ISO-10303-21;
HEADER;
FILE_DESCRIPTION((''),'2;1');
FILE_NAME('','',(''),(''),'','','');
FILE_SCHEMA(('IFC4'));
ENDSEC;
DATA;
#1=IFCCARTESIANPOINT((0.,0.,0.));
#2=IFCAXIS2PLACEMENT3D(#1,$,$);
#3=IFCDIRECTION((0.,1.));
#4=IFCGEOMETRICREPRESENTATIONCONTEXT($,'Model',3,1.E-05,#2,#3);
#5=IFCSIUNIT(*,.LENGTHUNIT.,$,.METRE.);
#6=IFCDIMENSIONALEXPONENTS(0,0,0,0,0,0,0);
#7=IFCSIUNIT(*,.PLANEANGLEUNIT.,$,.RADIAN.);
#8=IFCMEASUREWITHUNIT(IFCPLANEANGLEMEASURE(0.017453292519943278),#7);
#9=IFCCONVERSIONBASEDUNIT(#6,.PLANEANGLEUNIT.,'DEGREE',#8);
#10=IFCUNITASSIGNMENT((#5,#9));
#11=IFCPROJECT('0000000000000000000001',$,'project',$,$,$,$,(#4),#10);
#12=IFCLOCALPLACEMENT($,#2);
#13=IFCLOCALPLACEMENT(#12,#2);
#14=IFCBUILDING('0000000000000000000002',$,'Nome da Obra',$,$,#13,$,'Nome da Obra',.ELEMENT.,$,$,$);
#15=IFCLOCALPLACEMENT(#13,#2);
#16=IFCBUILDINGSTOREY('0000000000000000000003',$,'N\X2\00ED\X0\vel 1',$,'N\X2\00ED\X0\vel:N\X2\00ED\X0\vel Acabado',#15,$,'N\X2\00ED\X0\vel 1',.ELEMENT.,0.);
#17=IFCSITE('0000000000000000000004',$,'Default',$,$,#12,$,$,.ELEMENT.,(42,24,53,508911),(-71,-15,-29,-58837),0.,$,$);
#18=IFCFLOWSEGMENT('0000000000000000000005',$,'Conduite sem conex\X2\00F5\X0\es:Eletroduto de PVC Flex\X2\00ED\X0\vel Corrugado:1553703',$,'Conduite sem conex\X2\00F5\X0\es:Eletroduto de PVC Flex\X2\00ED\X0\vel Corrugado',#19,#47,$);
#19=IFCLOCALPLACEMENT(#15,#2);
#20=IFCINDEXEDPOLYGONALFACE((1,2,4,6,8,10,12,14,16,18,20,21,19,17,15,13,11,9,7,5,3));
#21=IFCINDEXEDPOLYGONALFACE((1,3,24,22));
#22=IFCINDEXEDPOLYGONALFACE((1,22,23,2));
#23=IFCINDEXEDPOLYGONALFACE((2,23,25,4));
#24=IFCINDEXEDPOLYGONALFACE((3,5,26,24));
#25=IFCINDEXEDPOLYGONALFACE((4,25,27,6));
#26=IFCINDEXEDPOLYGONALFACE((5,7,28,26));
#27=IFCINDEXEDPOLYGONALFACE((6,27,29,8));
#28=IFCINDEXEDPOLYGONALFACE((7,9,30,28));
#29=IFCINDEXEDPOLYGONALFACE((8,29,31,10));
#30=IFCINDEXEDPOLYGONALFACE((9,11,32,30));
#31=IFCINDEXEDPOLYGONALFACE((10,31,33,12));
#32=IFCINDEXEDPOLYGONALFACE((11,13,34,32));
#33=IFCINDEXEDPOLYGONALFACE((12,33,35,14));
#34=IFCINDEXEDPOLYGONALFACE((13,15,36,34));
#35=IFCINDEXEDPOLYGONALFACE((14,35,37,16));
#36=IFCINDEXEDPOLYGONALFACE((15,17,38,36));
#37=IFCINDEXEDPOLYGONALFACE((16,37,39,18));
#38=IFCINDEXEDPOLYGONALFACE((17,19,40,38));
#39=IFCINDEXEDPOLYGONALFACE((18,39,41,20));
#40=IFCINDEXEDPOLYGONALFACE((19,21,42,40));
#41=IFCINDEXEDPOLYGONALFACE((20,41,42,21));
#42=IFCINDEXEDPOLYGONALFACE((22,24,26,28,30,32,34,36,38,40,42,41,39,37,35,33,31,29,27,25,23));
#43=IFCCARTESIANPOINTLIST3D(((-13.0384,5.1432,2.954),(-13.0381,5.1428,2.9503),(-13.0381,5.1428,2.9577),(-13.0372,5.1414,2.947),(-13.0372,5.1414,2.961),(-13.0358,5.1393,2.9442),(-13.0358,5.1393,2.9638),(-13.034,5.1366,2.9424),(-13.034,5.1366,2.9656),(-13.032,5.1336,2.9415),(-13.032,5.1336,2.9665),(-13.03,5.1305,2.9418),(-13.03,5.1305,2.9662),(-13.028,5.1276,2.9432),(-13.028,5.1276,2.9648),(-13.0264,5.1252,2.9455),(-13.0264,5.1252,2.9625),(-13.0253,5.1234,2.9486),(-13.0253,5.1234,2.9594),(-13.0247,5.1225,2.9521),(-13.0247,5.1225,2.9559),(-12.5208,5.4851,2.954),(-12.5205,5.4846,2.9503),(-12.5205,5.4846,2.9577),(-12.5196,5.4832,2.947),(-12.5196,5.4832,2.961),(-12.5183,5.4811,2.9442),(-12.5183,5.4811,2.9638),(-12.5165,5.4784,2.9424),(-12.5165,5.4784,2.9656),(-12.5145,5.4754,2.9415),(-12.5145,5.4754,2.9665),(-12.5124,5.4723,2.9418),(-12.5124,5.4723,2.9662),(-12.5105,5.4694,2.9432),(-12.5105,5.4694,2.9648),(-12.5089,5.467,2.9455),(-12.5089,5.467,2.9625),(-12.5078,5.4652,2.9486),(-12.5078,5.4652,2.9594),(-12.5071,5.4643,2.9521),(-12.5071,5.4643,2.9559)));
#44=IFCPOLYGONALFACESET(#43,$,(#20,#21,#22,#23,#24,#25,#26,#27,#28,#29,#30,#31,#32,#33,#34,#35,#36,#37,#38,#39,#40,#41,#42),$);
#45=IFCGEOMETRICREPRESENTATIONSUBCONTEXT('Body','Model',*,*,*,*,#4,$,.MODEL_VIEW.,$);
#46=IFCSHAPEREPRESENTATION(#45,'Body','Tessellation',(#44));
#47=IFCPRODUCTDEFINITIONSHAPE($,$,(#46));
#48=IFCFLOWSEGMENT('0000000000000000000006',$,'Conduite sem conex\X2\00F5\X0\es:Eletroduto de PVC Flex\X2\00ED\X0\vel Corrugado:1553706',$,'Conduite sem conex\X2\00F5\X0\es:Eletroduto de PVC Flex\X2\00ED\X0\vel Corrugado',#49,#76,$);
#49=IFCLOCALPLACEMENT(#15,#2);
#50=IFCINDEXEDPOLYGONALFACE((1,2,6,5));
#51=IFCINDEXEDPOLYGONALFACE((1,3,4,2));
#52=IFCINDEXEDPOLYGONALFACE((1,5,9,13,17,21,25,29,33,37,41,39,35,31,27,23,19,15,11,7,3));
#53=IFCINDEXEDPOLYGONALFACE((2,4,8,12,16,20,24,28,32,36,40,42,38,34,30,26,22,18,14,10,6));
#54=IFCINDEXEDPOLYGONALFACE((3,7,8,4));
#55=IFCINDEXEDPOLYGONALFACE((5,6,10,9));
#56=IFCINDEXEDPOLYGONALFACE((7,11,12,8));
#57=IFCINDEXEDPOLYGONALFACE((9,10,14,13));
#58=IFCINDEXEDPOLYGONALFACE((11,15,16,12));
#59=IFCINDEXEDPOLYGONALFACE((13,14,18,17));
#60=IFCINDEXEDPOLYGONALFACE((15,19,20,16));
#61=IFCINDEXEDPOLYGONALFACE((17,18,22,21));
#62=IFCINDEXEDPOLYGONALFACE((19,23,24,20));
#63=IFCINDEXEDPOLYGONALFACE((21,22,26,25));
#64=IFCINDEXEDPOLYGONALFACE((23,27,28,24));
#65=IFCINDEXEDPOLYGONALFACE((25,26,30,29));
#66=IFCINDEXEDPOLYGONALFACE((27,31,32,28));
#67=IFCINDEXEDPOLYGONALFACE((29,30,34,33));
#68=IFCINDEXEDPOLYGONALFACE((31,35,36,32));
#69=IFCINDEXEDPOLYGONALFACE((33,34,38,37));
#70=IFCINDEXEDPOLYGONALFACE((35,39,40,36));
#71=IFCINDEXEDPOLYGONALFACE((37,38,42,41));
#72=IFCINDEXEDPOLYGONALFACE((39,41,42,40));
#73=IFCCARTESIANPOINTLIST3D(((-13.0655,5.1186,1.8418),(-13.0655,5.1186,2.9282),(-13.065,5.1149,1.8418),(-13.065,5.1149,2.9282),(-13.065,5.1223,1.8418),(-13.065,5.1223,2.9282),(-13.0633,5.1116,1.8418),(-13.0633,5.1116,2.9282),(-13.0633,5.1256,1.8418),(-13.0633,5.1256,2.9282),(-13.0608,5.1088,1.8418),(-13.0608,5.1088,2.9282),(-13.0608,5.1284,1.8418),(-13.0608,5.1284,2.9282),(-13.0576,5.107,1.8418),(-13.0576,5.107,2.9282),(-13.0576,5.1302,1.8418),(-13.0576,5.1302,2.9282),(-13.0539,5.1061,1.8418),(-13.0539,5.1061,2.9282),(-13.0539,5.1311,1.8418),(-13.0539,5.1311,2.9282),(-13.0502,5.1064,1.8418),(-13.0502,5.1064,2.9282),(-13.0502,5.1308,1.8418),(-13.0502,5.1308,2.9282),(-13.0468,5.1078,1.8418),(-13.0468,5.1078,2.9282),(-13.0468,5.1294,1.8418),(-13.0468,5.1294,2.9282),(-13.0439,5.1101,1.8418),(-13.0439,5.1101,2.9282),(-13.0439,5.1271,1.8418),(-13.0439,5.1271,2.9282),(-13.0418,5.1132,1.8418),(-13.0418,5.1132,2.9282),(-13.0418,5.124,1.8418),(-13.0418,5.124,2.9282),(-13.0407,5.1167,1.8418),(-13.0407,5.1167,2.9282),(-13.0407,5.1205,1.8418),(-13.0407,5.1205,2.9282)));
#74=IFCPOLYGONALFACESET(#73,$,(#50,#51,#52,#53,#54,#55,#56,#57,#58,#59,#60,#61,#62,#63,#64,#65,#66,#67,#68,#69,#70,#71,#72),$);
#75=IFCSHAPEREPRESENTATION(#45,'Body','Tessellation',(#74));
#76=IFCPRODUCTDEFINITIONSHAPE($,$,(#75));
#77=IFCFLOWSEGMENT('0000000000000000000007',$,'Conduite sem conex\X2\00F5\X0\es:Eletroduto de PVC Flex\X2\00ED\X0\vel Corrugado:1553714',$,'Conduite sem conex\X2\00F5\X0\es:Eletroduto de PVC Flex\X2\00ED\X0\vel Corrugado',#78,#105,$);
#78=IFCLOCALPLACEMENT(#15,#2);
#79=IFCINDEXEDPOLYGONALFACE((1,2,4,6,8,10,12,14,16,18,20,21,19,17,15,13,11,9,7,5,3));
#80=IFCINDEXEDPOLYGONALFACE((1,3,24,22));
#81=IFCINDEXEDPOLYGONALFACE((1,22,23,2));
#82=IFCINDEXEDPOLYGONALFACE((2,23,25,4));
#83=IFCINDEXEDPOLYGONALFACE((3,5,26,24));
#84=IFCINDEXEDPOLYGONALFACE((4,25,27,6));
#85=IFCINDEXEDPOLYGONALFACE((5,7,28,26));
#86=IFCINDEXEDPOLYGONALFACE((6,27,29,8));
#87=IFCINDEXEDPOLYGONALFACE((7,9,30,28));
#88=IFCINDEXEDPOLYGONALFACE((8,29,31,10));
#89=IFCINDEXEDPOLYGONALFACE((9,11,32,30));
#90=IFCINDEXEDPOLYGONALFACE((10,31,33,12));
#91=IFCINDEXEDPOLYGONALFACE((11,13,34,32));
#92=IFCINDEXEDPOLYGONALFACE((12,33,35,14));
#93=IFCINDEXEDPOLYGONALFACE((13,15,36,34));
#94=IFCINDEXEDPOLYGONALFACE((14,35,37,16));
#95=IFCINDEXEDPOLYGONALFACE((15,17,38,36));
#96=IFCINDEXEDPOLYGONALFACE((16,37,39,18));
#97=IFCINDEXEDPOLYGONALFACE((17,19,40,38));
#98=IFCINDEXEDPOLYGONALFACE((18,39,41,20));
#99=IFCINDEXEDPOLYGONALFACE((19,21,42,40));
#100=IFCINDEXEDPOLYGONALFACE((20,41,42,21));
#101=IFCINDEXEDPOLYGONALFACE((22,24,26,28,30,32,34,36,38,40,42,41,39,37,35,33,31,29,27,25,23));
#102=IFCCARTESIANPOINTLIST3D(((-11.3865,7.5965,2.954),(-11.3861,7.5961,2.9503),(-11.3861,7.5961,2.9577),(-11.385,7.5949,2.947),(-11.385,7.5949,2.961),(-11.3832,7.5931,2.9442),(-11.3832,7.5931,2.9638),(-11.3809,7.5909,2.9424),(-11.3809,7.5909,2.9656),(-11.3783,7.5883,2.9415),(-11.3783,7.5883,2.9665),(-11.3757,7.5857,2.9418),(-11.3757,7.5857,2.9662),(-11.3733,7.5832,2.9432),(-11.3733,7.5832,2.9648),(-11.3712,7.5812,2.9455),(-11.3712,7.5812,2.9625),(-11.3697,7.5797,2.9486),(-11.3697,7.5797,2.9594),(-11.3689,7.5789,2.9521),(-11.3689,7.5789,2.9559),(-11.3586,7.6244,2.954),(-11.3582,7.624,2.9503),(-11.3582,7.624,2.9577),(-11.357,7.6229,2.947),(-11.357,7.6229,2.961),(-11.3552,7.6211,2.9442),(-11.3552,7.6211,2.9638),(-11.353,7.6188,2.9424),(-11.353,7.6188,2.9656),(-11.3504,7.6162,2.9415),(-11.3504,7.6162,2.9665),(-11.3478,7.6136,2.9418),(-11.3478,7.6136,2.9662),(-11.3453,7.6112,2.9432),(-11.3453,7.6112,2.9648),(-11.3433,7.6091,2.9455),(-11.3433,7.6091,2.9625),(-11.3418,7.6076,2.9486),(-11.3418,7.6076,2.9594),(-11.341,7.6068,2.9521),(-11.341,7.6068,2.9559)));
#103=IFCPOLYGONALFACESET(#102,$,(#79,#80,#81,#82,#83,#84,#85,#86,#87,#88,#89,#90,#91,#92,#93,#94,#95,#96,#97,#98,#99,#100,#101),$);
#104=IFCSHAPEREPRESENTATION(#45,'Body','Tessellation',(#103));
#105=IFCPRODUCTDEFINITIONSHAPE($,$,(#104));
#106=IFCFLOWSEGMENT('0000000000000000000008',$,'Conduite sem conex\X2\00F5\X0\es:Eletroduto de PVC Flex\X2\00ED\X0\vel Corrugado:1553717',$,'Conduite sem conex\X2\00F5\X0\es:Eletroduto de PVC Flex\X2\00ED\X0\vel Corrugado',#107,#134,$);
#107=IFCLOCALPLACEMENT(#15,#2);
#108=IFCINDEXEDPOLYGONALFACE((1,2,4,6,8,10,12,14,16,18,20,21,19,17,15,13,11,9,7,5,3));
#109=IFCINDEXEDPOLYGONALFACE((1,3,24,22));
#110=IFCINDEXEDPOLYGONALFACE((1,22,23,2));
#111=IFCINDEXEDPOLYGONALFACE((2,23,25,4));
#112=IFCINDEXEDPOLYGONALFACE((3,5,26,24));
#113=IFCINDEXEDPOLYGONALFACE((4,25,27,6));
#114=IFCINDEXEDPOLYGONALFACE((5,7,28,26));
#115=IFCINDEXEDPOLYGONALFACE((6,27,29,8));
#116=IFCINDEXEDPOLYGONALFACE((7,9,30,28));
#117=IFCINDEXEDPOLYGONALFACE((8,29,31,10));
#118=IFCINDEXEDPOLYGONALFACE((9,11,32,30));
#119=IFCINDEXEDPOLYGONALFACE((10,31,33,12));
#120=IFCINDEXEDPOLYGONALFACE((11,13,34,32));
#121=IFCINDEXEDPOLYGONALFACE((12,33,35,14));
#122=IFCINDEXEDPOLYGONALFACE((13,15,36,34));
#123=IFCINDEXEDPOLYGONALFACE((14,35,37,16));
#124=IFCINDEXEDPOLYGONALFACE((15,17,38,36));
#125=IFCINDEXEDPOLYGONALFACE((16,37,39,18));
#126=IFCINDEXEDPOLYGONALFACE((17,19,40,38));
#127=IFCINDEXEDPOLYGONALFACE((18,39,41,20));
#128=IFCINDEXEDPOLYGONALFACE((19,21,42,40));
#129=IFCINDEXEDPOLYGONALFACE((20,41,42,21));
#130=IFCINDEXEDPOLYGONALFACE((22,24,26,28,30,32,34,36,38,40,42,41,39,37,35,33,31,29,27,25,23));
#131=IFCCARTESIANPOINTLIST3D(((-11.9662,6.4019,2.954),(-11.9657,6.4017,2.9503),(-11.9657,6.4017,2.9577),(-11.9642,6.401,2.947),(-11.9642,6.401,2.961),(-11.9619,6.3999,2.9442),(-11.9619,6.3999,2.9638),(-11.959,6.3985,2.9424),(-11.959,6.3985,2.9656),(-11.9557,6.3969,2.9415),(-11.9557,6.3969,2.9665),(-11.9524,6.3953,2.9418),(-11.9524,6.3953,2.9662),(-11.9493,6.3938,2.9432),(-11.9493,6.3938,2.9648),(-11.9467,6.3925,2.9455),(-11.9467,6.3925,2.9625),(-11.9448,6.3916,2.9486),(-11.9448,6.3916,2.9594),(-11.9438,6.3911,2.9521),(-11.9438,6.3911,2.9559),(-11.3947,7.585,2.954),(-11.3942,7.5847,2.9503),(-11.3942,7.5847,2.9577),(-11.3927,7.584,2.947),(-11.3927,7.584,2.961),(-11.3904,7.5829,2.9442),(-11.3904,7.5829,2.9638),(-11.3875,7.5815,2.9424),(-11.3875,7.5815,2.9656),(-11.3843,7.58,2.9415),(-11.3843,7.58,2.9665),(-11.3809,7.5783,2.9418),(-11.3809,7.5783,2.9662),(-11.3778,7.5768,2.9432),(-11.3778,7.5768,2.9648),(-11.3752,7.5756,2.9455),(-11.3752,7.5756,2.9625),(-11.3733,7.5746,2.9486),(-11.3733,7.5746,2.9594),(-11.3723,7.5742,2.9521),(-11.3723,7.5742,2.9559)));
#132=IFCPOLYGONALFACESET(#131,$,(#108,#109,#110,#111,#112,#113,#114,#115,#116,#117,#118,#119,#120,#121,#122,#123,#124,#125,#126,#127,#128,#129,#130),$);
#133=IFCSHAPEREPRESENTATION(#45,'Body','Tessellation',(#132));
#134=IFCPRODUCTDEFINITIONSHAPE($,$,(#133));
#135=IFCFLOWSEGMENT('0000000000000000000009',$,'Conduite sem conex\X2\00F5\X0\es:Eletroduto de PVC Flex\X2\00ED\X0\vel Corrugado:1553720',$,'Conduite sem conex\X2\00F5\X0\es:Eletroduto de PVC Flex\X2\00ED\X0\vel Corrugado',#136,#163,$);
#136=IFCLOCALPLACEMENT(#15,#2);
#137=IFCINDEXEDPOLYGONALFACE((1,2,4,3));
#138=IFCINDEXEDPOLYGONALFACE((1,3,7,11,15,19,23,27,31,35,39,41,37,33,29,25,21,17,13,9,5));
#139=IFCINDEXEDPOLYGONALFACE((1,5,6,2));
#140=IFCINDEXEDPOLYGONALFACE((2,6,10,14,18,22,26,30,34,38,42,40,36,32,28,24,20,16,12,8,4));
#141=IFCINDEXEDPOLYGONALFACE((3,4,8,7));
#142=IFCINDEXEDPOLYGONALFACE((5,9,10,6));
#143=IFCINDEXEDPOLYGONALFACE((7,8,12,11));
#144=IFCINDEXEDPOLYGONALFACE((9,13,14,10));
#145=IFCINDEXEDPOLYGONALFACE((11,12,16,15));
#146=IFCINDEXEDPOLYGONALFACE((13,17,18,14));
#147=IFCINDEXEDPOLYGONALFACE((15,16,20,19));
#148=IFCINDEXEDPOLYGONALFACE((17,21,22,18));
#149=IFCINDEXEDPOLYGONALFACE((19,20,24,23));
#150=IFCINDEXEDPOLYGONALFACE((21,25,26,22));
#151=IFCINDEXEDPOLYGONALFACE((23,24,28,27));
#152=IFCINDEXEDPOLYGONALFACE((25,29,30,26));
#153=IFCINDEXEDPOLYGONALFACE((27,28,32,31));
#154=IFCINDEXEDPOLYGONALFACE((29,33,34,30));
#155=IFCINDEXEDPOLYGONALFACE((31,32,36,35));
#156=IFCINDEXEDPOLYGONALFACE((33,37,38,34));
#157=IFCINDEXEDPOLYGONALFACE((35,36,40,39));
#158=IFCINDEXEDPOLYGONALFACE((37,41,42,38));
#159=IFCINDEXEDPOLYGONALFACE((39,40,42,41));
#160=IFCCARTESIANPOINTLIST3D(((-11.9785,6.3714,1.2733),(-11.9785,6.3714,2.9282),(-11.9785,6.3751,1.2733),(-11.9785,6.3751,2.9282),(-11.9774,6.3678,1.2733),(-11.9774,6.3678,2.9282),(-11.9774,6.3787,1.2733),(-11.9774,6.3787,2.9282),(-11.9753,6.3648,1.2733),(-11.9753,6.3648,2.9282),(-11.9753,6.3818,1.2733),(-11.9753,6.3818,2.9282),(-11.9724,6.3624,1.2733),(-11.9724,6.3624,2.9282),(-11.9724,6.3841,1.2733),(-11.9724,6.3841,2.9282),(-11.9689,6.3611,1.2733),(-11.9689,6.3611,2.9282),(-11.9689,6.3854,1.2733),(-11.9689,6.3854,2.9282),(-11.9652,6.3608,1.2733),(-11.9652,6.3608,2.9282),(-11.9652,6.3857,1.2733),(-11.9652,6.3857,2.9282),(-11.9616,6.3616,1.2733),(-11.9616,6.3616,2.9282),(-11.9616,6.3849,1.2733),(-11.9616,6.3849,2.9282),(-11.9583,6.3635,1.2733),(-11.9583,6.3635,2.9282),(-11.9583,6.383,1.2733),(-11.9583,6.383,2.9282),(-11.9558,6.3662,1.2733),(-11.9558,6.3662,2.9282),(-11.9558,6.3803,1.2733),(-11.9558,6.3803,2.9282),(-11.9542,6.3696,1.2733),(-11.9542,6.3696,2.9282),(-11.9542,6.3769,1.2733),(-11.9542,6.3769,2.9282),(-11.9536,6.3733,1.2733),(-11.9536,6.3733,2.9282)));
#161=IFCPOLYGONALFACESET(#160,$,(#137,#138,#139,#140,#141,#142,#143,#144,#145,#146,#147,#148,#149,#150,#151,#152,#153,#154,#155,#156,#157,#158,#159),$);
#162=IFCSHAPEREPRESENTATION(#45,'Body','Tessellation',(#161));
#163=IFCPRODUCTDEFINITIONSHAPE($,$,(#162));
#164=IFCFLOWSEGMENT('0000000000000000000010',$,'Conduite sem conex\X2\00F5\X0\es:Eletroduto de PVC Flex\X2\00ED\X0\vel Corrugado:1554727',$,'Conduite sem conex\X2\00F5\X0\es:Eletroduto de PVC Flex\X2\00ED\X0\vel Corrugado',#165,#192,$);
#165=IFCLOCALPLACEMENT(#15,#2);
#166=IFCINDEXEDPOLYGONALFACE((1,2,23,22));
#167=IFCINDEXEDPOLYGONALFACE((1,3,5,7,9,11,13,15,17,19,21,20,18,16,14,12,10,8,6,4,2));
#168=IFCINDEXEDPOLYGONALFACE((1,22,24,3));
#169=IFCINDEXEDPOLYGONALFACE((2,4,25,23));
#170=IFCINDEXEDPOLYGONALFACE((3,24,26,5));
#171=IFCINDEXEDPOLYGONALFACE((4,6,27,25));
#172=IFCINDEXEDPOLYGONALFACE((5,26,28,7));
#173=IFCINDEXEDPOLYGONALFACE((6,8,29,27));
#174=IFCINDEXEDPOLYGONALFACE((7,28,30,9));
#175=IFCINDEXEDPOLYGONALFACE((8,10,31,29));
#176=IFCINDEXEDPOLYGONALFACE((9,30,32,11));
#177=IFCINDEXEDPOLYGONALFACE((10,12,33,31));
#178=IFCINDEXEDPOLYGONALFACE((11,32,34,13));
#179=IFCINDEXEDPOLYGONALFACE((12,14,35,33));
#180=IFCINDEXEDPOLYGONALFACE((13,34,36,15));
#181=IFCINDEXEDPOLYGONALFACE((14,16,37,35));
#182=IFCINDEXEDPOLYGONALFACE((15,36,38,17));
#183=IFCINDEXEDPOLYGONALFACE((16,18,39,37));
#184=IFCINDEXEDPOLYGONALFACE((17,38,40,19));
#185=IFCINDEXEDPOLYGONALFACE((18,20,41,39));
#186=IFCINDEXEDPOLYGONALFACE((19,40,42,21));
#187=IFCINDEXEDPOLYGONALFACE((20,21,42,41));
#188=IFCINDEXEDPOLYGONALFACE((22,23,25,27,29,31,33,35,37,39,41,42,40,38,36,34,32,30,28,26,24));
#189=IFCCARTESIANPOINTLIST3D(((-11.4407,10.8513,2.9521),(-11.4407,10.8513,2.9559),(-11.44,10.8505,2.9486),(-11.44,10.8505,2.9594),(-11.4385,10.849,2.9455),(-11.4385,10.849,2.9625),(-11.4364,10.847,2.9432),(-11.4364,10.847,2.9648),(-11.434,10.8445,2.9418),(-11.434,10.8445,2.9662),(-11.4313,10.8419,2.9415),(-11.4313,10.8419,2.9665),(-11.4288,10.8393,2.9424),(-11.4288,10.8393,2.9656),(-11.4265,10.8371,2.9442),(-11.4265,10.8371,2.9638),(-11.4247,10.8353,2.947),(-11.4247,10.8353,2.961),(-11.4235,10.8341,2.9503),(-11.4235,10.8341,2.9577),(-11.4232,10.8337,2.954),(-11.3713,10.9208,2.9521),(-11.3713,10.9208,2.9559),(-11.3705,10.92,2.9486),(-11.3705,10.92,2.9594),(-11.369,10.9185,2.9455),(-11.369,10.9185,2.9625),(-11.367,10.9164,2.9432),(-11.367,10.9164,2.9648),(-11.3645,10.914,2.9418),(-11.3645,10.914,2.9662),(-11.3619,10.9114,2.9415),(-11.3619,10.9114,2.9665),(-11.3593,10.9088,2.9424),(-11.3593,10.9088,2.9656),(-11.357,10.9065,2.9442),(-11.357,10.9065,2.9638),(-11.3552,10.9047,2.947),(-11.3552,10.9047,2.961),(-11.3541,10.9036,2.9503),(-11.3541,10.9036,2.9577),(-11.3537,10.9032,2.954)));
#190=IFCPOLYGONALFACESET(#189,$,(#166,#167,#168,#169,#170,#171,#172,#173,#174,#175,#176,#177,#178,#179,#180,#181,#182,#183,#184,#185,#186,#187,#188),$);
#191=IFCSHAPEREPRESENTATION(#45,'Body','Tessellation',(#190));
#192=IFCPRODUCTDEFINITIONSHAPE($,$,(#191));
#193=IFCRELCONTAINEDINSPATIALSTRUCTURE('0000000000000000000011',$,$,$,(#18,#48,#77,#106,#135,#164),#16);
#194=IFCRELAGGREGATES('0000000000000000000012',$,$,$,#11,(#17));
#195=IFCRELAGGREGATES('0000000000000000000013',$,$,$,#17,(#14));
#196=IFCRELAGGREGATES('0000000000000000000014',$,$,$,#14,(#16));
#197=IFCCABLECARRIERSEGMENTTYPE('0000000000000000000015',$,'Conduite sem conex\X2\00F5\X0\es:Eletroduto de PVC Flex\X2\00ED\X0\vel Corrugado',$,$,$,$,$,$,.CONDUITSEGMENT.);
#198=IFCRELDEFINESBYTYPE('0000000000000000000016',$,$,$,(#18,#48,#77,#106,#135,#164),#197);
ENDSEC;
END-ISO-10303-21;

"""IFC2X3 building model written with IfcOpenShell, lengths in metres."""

from ifc_helpers import new_model, entity, si_unit, converted_unit, direction, frame, frame_2d, origin, origin_2d_with_axis, place, context, subcontext, project, spatial, circle, extrude, type_object, element, save


model = new_model("IFC2X3")

# Units and contexts
model_context = context("Model", 3, precision=1e-05, world=origin(), true_north=direction((0.0, 1.0)))
body_context = subcontext(model_context, "Body", "Model", "MODEL_VIEW")
ifc_project = project(units=[si_unit("LENGTHUNIT", "METRE"), converted_unit("PLANEANGLEUNIT", "DEGREE", entity("IfcPlaneAngleMeasure", 0.017453292519943278), si_unit("PLANEANGLEUNIT", "RADIAN"), dimensions=[0, 0, 0, 0, 0, 0, 0])], contexts=[model_context])

# Site, building, storey
site_placement = place(None, origin())
site = spatial("IfcSite", under=ifc_project, at=site_placement, Name="Default", CompositionType="ELEMENT", RefLatitude=(42, 24, 53, 508911), RefLongitude=(-71, -15, -29, -58837), RefElevation=0.0)
building_placement = place(site_placement, origin())
building = spatial("IfcBuilding", under=site, at=building_placement, Name="Nome da Obra", LongName="Nome da Obra", CompositionType="ELEMENT")
storey_placement = place(building_placement, origin())
storey = spatial("IfcBuildingStorey", under=building, at=storey_placement, Name="Nível 1", ObjectType="Nível:Nível Acabado", LongName="Nível 1", CompositionType="ELEMENT", Elevation=0.0)

# Flow segments
cable_carrier_segment_type = type_object("IfcCableCarrierSegmentType", Name="Conduite sem conexões:Eletroduto de PVC Flexível Corrugado", PredefinedType="CONDUITSEGMENT")
flow_segment_1_placement = place(storey_placement, origin())
element("IfcFlowSegment", 1, at=flow_segment_1_placement, inside=storey, type_object=cable_carrier_segment_type, Name="Conduite sem conexões:Eletroduto de PVC Flexível Corrugado:1553703", ObjectType="Conduite sem conexões:Eletroduto de PVC Flexível Corrugado", context=body_context, shape_type="SweptSolid", body=[
    extrude(circle(Radius=0.0125, at=frame_2d((0.0, 0.0), x_axis=(1.0, 0.0))), frame((-13.0315, 5.1328, 2.954), z_axis=(0.834434, 0.551108, 0.0), x_axis=(-0.551108, 0.834434, 0.0)), (0.0, 0.0, 1.0), 0.6202),
])
flow_segment_2_placement = place(storey_placement, origin())
element("IfcFlowSegment", 2, at=flow_segment_2_placement, inside=storey, type_object=cable_carrier_segment_type, Name="Conduite sem conexões:Eletroduto de PVC Flexível Corrugado:1553706", ObjectType="Conduite sem conexões:Eletroduto de PVC Flexível Corrugado", context=body_context, shape_type="SweptSolid", body=[
    extrude(circle(Radius=0.0125, at=frame_2d((0.0, 0.0), x_axis=(1.0, 0.0))), frame((-13.053, 5.1186, 1.8418), z_axis=(0.0, 0.0, 1.0), x_axis=(-1.0, 0.0, 0.0)), (0.0, 0.0, 1.0), 1.0864),
])
flow_segment_3_placement = place(storey_placement, origin())
element("IfcFlowSegment", 3, at=flow_segment_3_placement, inside=storey, type_object=cable_carrier_segment_type, Name="Conduite sem conexões:Eletroduto de PVC Flexível Corrugado:1553714", ObjectType="Conduite sem conexões:Eletroduto de PVC Flexível Corrugado", context=body_context, shape_type="SweptSolid", body=[
    extrude(circle(Radius=0.0125, at=frame_2d((0.0, 0.0), x_axis=(1.0, 0.0))), frame((-11.3777, 7.5876, 2.954), z_axis=(0.707107, 0.707107, 0.0), x_axis=(-0.707107, 0.707107, 0.0)), (0.0, 0.0, 1.0), 0.0395),
])
flow_segment_4_placement = place(storey_placement, origin())
element("IfcFlowSegment", 4, at=flow_segment_4_placement, inside=storey, type_object=cable_carrier_segment_type, Name="Conduite sem conexões:Eletroduto de PVC Flexível Corrugado:1553717", ObjectType="Conduite sem conexões:Eletroduto de PVC Flexível Corrugado", context=body_context, shape_type="SweptSolid", body=[
    extrude(circle(Radius=0.0125, at=origin_2d_with_axis()), frame((-11.9549, 6.3965, 2.954), z_axis=(0.43497, 0.900445, 0.0), x_axis=(-0.900445, 0.43497, 0.0)), (0.0, 0.0, 1.0), 1.3139),
])
flow_segment_5_placement = place(storey_placement, origin())
element("IfcFlowSegment", 5, at=flow_segment_5_placement, inside=storey, type_object=cable_carrier_segment_type, Name="Conduite sem conexões:Eletroduto de PVC Flexível Corrugado:1553720", ObjectType="Conduite sem conexões:Eletroduto de PVC Flexível Corrugado", context=body_context, shape_type="SweptSolid", body=[
    extrude(circle(Radius=0.0125, at=frame_2d((0.0, 0.0), x_axis=(1.0, 0.0))), frame((-11.9661, 6.3733, 1.2733)), (0.0, 0.0, 1.0), 1.655),
])
flow_segment_6_placement = place(storey_placement, origin())
element("IfcFlowSegment", 6, at=flow_segment_6_placement, inside=storey, type_object=cable_carrier_segment_type, Name="Conduite sem conexões:Eletroduto de PVC Flexível Corrugado:1554727", ObjectType="Conduite sem conexões:Eletroduto de PVC Flexível Corrugado", context=body_context, shape_type="SweptSolid", body=[
    extrude(circle(Radius=0.0125, at=frame_2d((0.0, 0.0), x_axis=(1.0, 0.0))), frame((-11.432, 10.8426, 2.954), z_axis=(0.707107, 0.707107, 0.0), x_axis=(0.707107, -0.707107, 0.0)), (0.0, 0.0, 1.0), 0.0982),
])

save(model, "model.ifc")
